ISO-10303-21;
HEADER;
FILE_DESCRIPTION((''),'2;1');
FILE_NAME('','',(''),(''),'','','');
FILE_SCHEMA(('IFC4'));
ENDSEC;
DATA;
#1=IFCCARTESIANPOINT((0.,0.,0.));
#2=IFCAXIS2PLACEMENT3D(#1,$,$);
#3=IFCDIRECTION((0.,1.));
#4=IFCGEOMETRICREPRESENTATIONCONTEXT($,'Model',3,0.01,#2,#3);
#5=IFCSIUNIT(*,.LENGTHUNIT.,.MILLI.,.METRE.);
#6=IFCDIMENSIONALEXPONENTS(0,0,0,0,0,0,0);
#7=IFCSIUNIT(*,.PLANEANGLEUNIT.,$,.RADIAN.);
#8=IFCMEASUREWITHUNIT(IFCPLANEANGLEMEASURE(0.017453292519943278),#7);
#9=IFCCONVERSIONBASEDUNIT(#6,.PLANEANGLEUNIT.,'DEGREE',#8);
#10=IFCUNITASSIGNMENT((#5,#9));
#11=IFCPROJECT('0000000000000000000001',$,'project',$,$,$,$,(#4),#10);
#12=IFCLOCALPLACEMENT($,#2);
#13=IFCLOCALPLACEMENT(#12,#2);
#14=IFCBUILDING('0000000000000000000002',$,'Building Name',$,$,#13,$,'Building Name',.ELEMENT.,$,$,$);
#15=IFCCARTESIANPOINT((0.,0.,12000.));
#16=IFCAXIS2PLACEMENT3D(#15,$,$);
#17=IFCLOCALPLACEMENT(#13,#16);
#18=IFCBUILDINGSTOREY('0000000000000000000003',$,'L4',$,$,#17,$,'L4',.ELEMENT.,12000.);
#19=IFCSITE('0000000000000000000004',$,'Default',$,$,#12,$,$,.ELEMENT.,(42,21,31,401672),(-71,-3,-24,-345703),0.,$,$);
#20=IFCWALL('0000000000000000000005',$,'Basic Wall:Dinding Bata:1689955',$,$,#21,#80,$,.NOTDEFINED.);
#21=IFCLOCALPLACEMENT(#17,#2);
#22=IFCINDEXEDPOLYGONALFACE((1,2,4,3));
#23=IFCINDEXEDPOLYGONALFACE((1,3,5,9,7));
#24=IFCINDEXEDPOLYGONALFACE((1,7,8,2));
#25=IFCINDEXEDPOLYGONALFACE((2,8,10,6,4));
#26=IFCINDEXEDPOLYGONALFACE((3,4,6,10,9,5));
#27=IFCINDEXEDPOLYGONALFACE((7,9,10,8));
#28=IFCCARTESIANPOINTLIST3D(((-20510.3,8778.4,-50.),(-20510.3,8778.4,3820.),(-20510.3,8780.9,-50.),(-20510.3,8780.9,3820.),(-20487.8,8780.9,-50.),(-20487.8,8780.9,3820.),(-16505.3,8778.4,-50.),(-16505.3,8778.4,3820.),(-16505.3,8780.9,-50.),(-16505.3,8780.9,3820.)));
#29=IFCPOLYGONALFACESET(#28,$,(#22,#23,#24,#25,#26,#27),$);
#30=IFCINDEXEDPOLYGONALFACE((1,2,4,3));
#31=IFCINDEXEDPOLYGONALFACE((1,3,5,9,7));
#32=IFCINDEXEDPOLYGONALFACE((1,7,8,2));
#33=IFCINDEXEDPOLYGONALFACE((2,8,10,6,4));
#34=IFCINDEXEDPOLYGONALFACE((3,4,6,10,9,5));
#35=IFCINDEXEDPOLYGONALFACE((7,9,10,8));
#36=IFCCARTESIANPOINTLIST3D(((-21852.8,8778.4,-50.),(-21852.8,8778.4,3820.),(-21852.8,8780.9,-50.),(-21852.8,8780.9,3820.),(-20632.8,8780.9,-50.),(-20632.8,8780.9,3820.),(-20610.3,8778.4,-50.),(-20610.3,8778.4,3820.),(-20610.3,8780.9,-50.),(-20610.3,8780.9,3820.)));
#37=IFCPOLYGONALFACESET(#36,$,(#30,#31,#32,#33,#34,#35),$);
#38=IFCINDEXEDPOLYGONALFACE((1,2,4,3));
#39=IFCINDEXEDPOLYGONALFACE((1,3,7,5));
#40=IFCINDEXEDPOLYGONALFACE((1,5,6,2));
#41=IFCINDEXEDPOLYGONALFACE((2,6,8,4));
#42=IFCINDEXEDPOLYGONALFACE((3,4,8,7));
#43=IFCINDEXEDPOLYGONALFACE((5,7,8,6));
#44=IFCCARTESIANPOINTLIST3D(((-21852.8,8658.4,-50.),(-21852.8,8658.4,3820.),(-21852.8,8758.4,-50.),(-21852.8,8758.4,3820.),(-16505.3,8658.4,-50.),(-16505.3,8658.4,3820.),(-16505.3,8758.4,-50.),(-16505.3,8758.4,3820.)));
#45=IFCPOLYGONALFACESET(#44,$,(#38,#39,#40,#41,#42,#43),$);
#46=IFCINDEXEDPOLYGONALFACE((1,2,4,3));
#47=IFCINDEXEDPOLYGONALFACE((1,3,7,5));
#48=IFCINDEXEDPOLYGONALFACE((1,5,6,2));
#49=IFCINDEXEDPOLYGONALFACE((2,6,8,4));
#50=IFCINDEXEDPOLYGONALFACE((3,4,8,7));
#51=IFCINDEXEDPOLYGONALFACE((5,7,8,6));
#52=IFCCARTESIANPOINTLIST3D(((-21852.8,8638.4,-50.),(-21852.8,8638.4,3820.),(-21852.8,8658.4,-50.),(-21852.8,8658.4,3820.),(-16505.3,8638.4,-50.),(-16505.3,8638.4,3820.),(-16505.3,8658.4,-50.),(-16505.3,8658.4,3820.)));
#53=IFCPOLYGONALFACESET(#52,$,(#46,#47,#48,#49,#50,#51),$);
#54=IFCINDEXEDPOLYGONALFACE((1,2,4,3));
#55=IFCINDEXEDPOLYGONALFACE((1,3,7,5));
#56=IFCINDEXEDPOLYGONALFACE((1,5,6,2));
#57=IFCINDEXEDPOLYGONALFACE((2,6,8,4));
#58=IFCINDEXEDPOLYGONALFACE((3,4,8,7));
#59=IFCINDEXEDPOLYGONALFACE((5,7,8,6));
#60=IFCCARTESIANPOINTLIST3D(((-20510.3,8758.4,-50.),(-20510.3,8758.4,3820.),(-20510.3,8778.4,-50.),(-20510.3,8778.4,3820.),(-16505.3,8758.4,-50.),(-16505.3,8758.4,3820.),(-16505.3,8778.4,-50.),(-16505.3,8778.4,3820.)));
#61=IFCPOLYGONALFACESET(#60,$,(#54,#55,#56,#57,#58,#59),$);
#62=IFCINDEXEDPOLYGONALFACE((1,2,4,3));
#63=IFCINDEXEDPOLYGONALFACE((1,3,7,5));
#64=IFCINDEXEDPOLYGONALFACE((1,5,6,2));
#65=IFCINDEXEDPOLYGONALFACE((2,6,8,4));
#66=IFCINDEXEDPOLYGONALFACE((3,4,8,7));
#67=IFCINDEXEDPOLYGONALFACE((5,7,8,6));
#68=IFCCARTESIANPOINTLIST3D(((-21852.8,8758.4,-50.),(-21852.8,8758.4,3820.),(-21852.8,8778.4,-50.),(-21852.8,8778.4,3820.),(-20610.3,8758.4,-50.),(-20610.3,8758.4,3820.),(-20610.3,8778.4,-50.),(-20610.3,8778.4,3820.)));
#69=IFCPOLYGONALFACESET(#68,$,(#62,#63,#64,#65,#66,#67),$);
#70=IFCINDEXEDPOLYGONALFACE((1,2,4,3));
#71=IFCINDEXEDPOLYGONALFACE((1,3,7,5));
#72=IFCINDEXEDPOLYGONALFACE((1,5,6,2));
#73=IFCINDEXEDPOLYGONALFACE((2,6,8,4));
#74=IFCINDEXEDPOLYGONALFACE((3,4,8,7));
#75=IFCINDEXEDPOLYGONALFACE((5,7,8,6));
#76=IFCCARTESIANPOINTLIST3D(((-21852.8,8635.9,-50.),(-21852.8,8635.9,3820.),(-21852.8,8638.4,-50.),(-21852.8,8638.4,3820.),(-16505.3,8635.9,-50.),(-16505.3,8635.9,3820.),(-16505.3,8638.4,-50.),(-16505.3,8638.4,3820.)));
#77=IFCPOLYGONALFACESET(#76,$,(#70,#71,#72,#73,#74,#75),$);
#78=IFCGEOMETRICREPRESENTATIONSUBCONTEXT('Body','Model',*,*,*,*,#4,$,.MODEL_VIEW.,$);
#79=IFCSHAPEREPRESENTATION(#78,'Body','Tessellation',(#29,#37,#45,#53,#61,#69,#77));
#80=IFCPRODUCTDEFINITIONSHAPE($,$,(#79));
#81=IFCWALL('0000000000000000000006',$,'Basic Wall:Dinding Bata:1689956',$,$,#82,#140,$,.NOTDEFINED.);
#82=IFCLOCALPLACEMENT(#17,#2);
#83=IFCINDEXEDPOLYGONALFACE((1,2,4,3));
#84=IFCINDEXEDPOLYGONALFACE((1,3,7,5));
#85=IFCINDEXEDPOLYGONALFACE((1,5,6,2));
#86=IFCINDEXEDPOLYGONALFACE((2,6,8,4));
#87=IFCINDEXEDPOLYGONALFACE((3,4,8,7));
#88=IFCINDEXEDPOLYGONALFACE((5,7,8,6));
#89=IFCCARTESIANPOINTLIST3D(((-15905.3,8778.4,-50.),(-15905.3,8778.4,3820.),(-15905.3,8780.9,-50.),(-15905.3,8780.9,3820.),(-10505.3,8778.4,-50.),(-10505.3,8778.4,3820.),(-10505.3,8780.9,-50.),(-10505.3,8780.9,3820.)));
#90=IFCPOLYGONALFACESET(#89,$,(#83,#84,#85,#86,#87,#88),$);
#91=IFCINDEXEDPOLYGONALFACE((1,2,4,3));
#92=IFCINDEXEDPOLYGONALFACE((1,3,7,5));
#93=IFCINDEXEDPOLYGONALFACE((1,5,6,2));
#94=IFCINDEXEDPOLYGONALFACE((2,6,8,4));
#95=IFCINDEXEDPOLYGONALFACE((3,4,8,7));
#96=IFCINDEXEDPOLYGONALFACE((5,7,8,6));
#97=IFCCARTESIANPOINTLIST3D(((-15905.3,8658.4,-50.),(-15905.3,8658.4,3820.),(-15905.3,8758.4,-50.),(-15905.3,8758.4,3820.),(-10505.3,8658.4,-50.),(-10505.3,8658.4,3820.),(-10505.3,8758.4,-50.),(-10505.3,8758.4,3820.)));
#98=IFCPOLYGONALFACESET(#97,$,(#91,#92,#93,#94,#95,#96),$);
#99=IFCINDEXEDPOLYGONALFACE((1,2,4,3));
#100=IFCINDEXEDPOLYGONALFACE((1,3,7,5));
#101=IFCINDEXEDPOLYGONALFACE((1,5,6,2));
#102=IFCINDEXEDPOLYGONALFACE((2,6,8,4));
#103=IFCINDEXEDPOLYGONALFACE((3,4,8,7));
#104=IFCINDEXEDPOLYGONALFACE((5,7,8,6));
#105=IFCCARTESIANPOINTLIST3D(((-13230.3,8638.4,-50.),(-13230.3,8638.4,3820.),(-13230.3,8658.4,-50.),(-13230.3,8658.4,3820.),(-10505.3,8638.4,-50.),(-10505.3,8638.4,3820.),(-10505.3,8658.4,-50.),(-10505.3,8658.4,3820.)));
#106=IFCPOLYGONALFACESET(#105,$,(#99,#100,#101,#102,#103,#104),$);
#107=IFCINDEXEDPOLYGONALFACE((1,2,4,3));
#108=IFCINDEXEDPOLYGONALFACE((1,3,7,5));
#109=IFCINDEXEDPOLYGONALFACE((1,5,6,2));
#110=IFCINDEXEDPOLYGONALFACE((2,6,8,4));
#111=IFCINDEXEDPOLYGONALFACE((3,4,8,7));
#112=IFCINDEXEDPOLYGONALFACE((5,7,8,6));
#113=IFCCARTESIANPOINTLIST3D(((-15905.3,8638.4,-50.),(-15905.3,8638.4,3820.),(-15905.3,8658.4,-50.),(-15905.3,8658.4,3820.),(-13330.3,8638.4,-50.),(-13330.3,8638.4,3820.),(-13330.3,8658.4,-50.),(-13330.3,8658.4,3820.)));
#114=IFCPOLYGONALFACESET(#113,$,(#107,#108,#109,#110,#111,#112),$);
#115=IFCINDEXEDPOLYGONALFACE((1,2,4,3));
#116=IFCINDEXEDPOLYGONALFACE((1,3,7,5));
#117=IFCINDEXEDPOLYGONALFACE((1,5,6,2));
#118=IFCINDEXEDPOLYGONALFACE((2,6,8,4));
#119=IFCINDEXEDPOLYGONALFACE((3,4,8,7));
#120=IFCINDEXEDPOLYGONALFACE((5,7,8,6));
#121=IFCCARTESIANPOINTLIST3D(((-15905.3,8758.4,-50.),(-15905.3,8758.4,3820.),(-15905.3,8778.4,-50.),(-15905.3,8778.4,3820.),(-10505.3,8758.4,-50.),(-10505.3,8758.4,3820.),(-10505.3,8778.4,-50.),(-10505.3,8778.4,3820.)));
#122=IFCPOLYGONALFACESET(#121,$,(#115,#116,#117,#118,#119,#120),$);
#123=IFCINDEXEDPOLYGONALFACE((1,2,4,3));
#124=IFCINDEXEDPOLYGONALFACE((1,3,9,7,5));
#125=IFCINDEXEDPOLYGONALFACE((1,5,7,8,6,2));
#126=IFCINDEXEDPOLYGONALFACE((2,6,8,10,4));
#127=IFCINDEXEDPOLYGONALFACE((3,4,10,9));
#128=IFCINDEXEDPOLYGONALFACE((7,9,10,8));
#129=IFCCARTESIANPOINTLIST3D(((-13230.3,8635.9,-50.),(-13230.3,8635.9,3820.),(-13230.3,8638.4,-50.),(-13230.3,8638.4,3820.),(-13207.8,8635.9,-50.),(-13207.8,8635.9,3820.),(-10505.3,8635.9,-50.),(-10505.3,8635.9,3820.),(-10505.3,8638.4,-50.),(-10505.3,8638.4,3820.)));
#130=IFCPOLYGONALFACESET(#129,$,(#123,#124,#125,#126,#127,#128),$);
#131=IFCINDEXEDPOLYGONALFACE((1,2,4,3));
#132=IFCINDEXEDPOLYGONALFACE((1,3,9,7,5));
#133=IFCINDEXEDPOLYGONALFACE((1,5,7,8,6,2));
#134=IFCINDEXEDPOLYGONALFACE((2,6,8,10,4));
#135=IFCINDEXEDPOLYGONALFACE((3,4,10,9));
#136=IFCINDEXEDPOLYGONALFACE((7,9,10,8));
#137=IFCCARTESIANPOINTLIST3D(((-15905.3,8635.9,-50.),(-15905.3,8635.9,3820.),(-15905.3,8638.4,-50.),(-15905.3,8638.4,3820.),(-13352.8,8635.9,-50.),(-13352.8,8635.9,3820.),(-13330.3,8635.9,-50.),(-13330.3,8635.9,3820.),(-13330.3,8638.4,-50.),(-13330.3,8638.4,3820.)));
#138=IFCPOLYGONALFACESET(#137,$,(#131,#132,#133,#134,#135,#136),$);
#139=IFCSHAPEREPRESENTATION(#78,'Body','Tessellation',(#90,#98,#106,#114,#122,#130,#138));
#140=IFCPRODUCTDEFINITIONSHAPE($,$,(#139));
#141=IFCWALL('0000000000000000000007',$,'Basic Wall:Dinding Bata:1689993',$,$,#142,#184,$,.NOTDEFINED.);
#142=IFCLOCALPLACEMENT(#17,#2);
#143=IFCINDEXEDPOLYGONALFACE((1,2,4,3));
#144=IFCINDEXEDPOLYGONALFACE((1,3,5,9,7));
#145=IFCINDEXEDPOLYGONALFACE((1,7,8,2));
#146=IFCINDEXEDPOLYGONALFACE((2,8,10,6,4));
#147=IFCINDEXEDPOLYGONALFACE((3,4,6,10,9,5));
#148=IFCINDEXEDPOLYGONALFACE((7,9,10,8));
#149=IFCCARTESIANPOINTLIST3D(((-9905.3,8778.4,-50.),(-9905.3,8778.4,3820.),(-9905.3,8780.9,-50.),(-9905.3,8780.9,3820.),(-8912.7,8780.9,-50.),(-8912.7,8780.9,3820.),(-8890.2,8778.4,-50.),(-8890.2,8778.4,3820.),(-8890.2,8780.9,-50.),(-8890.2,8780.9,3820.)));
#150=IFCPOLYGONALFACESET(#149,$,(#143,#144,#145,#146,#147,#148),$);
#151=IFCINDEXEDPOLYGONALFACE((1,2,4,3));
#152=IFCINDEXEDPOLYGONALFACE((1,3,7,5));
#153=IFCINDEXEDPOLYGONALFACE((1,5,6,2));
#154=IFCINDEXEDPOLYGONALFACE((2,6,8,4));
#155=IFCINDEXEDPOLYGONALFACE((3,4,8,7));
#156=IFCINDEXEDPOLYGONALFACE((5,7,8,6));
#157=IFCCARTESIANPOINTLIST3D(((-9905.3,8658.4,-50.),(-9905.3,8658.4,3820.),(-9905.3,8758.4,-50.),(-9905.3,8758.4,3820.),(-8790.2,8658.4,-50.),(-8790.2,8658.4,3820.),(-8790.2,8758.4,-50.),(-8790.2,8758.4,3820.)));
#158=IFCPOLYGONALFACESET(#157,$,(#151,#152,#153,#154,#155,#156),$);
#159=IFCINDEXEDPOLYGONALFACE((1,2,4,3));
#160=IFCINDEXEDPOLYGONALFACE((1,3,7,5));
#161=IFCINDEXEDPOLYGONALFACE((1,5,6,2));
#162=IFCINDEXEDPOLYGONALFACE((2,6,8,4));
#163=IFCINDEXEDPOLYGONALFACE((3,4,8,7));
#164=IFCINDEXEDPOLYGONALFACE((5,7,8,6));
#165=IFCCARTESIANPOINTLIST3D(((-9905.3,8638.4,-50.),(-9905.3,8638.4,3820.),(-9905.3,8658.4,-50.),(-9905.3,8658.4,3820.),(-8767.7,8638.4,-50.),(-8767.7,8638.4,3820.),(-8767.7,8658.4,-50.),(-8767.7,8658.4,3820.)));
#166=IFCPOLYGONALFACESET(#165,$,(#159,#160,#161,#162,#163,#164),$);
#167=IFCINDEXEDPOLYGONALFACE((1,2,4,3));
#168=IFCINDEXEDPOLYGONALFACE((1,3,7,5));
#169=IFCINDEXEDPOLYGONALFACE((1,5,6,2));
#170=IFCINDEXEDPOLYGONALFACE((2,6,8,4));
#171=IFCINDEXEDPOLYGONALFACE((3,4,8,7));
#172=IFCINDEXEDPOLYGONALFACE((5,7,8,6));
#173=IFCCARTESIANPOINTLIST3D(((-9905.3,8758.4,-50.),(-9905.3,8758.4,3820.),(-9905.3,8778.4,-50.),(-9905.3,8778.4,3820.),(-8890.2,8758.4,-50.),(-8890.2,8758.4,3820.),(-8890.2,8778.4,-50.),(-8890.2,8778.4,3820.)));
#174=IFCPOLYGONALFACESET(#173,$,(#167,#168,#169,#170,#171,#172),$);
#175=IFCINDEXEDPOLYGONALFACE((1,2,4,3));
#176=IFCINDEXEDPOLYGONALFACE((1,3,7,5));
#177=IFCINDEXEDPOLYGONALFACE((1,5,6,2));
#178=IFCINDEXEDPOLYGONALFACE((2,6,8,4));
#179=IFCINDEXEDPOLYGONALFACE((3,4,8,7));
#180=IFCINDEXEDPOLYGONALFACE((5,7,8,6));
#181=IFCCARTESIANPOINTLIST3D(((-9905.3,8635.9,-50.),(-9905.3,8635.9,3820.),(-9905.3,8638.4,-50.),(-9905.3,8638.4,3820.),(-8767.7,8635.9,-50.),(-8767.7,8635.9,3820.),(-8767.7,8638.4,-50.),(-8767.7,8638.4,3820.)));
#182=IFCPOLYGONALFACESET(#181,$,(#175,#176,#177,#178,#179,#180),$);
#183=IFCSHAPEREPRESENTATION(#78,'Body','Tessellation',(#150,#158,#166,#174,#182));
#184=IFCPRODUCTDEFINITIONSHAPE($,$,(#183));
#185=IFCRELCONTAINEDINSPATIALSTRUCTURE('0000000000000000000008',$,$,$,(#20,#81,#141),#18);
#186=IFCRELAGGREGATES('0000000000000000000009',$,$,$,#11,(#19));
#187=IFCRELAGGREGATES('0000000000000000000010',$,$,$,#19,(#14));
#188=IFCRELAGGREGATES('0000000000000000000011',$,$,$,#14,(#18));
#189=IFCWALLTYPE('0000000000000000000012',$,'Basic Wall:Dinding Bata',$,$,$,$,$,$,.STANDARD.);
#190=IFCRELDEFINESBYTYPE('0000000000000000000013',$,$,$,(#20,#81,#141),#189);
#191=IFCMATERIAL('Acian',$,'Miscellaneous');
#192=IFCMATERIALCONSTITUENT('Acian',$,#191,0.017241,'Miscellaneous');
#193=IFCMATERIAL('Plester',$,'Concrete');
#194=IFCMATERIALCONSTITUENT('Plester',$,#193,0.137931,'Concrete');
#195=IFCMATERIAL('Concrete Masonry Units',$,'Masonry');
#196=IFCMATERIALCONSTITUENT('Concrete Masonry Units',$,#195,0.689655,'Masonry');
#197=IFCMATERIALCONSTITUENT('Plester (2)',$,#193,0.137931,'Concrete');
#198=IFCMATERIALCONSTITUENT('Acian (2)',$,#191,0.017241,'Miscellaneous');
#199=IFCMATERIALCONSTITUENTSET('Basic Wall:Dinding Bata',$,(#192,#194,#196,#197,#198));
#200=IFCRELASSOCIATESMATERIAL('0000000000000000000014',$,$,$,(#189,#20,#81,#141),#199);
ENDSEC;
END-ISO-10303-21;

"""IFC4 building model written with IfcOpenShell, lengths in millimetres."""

from ifc_helpers import new_model, entity, si_unit, converted_unit, direction, frame, origin, place, context, subcontext, project, spatial, indexed_curve, outline, extrude, material, constituent, constituent_set, type_object, element, save


model = new_model("IFC4")

# Units and contexts
model_context = context("Model", 3, precision=0.01, world=origin(), true_north=direction((0.0, 1.0)))
body_context = subcontext(model_context, "Body", "Model", "MODEL_VIEW")
ifc_project = project(units=[si_unit("LENGTHUNIT", "METRE", prefix="MILLI"), converted_unit("PLANEANGLEUNIT", "DEGREE", entity("IfcPlaneAngleMeasure", 0.017453292519943278), si_unit("PLANEANGLEUNIT", "RADIAN"), dimensions=[0, 0, 0, 0, 0, 0, 0])], contexts=[model_context])

# Site, building, storey
site_placement = place(None, origin())
site = spatial("IfcSite", under=ifc_project, at=site_placement, Name="Default", CompositionType="ELEMENT", RefLatitude=(42, 21, 31, 401672), RefLongitude=(-71, -3, -24, -345703), RefElevation=0.0)
building_placement = place(site_placement, origin())
building = spatial("IfcBuilding", under=site, at=building_placement, Name="Building Name", LongName="Building Name", CompositionType="ELEMENT")
storey_placement = place(building_placement, frame((0.0, 0.0, 12000.0)))
storey = spatial("IfcBuildingStorey", under=building, at=storey_placement, Name="L4", LongName="L4", CompositionType="ELEMENT", Elevation=12000.0)

# Walls
ifc_material_1 = material(Name="Acian", Category="Miscellaneous")
ifc_constituent_1 = constituent(ifc_material_1, Name="Acian", Category="Miscellaneous", fraction=0.017241)
ifc_material_2 = material(Name="Plester", Category="Concrete")
ifc_constituent_2 = constituent(ifc_material_2, Name="Plester", Category="Concrete", fraction=0.137931)
ifc_material_3 = material(Name="Concrete Masonry Units", Category="Masonry")
ifc_constituent_3 = constituent(ifc_material_3, Name="Concrete Masonry Units", Category="Masonry", fraction=0.689655)
ifc_constituent_4 = constituent(ifc_material_2, Name="Plester (2)", Category="Concrete", fraction=0.137931)
ifc_constituent_5 = constituent(ifc_material_1, Name="Acian (2)", Category="Miscellaneous", fraction=0.017241)
ifc_constituent_set = constituent_set(constituents=[ifc_constituent_1, ifc_constituent_2, ifc_constituent_3, ifc_constituent_4, ifc_constituent_5], Name="Basic Wall:Dinding Bata")
wall_type = type_object("IfcWallType", Name="Basic Wall:Dinding Bata", PredefinedType="STANDARD", material=ifc_constituent_set)
wall_1_placement = place(storey_placement, frame((-21852.8, 8708.4, -50.0)))
element("IfcWall", 1, at=wall_1_placement, inside=storey, type_object=wall_type, material=ifc_constituent_set, Name="Basic Wall:Dinding Bata:1689955", PredefinedType="NOTDEFINED", context=body_context, shape_type="SweptSolid", body=[
    extrude(outline(indexed_curve([(1584.0, -1.0), (1606.5, -1.0), (1606.5, 1.5), (-2398.5, 1.5), (-2398.5, -1.0), (1584.0, -1.0)], self_intersect=False)), frame((2949.0, 71.5, 0.0), z_axis=(0.0, 0.0, 1.0), x_axis=(-1.0, 0.0, 0.0)), (0.0, 0.0, 1.0), 3870.0),
    extrude(outline(indexed_curve([(-741.0, -1.5), (501.5, -1.5), (501.5, 1.0), (479.0, 1.0), (-741.0, 1.0), (-741.0, -1.5)], self_intersect=False)), frame((741.0, 71.5, 0.0)), (0.0, 0.0, 1.0), 3870.0),
    extrude(outline(indexed_curve([(-2673.7, -50.0), (2673.7, -50.0), (2673.7, 50.0), (-2673.7, 50.0), (-2673.7, -50.0)], self_intersect=False)), frame((2673.7, 0.0, 0.0)), (0.0, 0.0, 1.0), 3870.0),
    extrude(outline(indexed_curve([(-2673.7, -10.0), (2673.7, -10.0), (2673.7, 10.0), (-2673.7, 10.0), (-2673.7, -10.0)], self_intersect=False)), frame((2673.7, -60.0, 0.0)), (0.0, 0.0, 1.0), 3870.0),
    extrude(outline(indexed_curve([(-2002.5, -10.0), (2002.5, -10.0), (2002.5, 10.0), (-2002.5, 10.0), (-2002.5, -10.0)], self_intersect=False)), frame((3345.0, 60.0, 0.0), z_axis=(0.0, 0.0, 1.0), x_axis=(-1.0, 0.0, 0.0)), (0.0, 0.0, 1.0), 3870.0),
    extrude(outline(indexed_curve([(-621.3, -10.0), (621.3, -10.0), (621.3, 10.0), (-621.3, 10.0), (-621.3, -10.0)], self_intersect=False)), frame((621.3, 60.0, 0.0)), (0.0, 0.0, 1.0), 3870.0),
    extrude(outline(indexed_curve([(-1.3, -2673.7), (1.2, -2673.7), (1.3, 2673.7), (-1.2, 2673.7), (-1.3, -2673.7)], self_intersect=False)), frame((2673.7, -71.3, 0.0), z_axis=(0.0, 0.0, 1.0), x_axis=(0.0, 1.0, 0.0)), (0.0, 0.0, 1.0), 3870.0),
])
wall_2_placement = place(storey_placement, frame((-15905.3, 8708.4, -50.0)))
element("IfcWall", 2, at=wall_2_placement, inside=storey, type_object=wall_type, material=ifc_constituent_set, Name="Basic Wall:Dinding Bata:1689956", PredefinedType="NOTDEFINED", context=body_context, shape_type="SweptSolid", body=[
    extrude(outline(indexed_curve([(-1.3, -2700.0), (1.2, -2700.0), (1.3, 2700.0), (-1.2, 2700.0), (-1.3, -2700.0)], self_intersect=False)), frame((2700.0, 71.3, 0.0), z_axis=(0.0, 0.0, 1.0), x_axis=(0.0, -1.0, 0.0)), (0.0, 0.0, 1.0), 3870.0),
    extrude(outline(indexed_curve([(-2700.0, -50.0), (2700.0, -50.0), (2700.0, 50.0), (-2700.0, 50.0), (-2700.0, -50.0)], self_intersect=False)), frame((2700.0, 0.0, 0.0)), (0.0, 0.0, 1.0), 3870.0),
    extrude(outline(indexed_curve([(-1362.5, -10.0), (1362.5, -10.0), (1362.5, 10.0), (-1362.5, 10.0), (-1362.5, -10.0)], self_intersect=False)), frame((4037.5, -60.0, 0.0), z_axis=(0.0, 0.0, 1.0), x_axis=(-1.0, 0.0, 0.0)), (0.0, 0.0, 1.0), 3870.0),
    extrude(outline(indexed_curve([(-1287.5, -10.0), (1287.5, -10.0), (1287.5, 10.0), (-1287.5, 10.0), (-1287.5, -10.0)], self_intersect=False)), frame((1287.5, -60.0, 0.0)), (0.0, 0.0, 1.0), 3870.0),
    extrude(outline(indexed_curve([(-2700.0, -10.0), (2700.0, -10.0), (2700.0, 10.0), (-2700.0, 10.0), (-2700.0, -10.0)], self_intersect=False)), frame((2700.0, 60.0, 0.0)), (0.0, 0.0, 1.0), 3870.0),
    extrude(outline(indexed_curve([(-1.0, -1630.5), (1.5, -1630.5), (1.5, 1094.5), (-1.0, 1094.5), (-1.0, 1072.0), (-1.0, -1630.5)], self_intersect=False)), frame((3769.5, -71.5, 0.0), z_axis=(0.0, 0.0, 1.0), x_axis=(0.0, 1.0, 0.0)), (0.0, 0.0, 1.0), 3870.0),
    extrude(outline(indexed_curve([(1012.0, -1.0), (1034.5, -1.0), (1034.5, 1.5), (-1540.5, 1.5), (-1540.5, -1.0), (1012.0, -1.0)], self_intersect=False)), frame((1540.5, -71.5, 0.0)), (0.0, 0.0, 1.0), 3870.0),
])
wall_3_placement = place(storey_placement, frame((-9905.3, 8708.4, -50.0)))
element("IfcWall", 3, at=wall_3_placement, inside=storey, type_object=wall_type, material=ifc_constituent_set, Name="Basic Wall:Dinding Bata:1689993", PredefinedType="NOTDEFINED", context=body_context, shape_type="SweptSolid", body=[
    extrude(outline(indexed_curve([(-388.0, -1.0), (604.5, -1.0), (604.5, 1.5), (-410.5, 1.5), (-410.5, -1.0), (-388.0, -1.0)], self_intersect=False)), frame((604.5, 71.5, 0.0), z_axis=(0.0, 0.0, 1.0), x_axis=(-1.0, 0.0, 0.0)), (0.0, 0.0, 1.0), 3870.0),
    extrude(outline(indexed_curve([(-557.5, -50.0), (557.5, -50.0), (557.5, 50.0), (-557.5, 50.0), (-557.5, -50.0)], self_intersect=False)), frame((557.5, 0.0, 0.0)), (0.0, 0.0, 1.0), 3870.0),
    extrude(outline(indexed_curve([(-568.8, -10.0), (568.8, -10.0), (568.8, 10.0), (-568.8, 10.0), (-568.8, -10.0)], self_intersect=False)), frame((568.8, -60.0, 0.0)), (0.0, 0.0, 1.0), 3870.0),
    extrude(outline(indexed_curve([(-507.5, -10.0), (507.5, -10.0), (507.5, 10.0), (-507.5, 10.0), (-507.5, -10.0)], self_intersect=False)), frame((507.5, 60.0, 0.0)), (0.0, 0.0, 1.0), 3870.0),
    extrude(outline(indexed_curve([(-1.3, -568.8), (1.2, -568.8), (1.3, 568.8), (-1.2, 568.8), (-1.3, -568.8)], self_intersect=False)), frame((568.8, -71.3, 0.0), z_axis=(0.0, 0.0, 1.0), x_axis=(0.0, 1.0, 0.0)), (0.0, 0.0, 1.0), 3870.0),
])

save(model, "model.ifc")
